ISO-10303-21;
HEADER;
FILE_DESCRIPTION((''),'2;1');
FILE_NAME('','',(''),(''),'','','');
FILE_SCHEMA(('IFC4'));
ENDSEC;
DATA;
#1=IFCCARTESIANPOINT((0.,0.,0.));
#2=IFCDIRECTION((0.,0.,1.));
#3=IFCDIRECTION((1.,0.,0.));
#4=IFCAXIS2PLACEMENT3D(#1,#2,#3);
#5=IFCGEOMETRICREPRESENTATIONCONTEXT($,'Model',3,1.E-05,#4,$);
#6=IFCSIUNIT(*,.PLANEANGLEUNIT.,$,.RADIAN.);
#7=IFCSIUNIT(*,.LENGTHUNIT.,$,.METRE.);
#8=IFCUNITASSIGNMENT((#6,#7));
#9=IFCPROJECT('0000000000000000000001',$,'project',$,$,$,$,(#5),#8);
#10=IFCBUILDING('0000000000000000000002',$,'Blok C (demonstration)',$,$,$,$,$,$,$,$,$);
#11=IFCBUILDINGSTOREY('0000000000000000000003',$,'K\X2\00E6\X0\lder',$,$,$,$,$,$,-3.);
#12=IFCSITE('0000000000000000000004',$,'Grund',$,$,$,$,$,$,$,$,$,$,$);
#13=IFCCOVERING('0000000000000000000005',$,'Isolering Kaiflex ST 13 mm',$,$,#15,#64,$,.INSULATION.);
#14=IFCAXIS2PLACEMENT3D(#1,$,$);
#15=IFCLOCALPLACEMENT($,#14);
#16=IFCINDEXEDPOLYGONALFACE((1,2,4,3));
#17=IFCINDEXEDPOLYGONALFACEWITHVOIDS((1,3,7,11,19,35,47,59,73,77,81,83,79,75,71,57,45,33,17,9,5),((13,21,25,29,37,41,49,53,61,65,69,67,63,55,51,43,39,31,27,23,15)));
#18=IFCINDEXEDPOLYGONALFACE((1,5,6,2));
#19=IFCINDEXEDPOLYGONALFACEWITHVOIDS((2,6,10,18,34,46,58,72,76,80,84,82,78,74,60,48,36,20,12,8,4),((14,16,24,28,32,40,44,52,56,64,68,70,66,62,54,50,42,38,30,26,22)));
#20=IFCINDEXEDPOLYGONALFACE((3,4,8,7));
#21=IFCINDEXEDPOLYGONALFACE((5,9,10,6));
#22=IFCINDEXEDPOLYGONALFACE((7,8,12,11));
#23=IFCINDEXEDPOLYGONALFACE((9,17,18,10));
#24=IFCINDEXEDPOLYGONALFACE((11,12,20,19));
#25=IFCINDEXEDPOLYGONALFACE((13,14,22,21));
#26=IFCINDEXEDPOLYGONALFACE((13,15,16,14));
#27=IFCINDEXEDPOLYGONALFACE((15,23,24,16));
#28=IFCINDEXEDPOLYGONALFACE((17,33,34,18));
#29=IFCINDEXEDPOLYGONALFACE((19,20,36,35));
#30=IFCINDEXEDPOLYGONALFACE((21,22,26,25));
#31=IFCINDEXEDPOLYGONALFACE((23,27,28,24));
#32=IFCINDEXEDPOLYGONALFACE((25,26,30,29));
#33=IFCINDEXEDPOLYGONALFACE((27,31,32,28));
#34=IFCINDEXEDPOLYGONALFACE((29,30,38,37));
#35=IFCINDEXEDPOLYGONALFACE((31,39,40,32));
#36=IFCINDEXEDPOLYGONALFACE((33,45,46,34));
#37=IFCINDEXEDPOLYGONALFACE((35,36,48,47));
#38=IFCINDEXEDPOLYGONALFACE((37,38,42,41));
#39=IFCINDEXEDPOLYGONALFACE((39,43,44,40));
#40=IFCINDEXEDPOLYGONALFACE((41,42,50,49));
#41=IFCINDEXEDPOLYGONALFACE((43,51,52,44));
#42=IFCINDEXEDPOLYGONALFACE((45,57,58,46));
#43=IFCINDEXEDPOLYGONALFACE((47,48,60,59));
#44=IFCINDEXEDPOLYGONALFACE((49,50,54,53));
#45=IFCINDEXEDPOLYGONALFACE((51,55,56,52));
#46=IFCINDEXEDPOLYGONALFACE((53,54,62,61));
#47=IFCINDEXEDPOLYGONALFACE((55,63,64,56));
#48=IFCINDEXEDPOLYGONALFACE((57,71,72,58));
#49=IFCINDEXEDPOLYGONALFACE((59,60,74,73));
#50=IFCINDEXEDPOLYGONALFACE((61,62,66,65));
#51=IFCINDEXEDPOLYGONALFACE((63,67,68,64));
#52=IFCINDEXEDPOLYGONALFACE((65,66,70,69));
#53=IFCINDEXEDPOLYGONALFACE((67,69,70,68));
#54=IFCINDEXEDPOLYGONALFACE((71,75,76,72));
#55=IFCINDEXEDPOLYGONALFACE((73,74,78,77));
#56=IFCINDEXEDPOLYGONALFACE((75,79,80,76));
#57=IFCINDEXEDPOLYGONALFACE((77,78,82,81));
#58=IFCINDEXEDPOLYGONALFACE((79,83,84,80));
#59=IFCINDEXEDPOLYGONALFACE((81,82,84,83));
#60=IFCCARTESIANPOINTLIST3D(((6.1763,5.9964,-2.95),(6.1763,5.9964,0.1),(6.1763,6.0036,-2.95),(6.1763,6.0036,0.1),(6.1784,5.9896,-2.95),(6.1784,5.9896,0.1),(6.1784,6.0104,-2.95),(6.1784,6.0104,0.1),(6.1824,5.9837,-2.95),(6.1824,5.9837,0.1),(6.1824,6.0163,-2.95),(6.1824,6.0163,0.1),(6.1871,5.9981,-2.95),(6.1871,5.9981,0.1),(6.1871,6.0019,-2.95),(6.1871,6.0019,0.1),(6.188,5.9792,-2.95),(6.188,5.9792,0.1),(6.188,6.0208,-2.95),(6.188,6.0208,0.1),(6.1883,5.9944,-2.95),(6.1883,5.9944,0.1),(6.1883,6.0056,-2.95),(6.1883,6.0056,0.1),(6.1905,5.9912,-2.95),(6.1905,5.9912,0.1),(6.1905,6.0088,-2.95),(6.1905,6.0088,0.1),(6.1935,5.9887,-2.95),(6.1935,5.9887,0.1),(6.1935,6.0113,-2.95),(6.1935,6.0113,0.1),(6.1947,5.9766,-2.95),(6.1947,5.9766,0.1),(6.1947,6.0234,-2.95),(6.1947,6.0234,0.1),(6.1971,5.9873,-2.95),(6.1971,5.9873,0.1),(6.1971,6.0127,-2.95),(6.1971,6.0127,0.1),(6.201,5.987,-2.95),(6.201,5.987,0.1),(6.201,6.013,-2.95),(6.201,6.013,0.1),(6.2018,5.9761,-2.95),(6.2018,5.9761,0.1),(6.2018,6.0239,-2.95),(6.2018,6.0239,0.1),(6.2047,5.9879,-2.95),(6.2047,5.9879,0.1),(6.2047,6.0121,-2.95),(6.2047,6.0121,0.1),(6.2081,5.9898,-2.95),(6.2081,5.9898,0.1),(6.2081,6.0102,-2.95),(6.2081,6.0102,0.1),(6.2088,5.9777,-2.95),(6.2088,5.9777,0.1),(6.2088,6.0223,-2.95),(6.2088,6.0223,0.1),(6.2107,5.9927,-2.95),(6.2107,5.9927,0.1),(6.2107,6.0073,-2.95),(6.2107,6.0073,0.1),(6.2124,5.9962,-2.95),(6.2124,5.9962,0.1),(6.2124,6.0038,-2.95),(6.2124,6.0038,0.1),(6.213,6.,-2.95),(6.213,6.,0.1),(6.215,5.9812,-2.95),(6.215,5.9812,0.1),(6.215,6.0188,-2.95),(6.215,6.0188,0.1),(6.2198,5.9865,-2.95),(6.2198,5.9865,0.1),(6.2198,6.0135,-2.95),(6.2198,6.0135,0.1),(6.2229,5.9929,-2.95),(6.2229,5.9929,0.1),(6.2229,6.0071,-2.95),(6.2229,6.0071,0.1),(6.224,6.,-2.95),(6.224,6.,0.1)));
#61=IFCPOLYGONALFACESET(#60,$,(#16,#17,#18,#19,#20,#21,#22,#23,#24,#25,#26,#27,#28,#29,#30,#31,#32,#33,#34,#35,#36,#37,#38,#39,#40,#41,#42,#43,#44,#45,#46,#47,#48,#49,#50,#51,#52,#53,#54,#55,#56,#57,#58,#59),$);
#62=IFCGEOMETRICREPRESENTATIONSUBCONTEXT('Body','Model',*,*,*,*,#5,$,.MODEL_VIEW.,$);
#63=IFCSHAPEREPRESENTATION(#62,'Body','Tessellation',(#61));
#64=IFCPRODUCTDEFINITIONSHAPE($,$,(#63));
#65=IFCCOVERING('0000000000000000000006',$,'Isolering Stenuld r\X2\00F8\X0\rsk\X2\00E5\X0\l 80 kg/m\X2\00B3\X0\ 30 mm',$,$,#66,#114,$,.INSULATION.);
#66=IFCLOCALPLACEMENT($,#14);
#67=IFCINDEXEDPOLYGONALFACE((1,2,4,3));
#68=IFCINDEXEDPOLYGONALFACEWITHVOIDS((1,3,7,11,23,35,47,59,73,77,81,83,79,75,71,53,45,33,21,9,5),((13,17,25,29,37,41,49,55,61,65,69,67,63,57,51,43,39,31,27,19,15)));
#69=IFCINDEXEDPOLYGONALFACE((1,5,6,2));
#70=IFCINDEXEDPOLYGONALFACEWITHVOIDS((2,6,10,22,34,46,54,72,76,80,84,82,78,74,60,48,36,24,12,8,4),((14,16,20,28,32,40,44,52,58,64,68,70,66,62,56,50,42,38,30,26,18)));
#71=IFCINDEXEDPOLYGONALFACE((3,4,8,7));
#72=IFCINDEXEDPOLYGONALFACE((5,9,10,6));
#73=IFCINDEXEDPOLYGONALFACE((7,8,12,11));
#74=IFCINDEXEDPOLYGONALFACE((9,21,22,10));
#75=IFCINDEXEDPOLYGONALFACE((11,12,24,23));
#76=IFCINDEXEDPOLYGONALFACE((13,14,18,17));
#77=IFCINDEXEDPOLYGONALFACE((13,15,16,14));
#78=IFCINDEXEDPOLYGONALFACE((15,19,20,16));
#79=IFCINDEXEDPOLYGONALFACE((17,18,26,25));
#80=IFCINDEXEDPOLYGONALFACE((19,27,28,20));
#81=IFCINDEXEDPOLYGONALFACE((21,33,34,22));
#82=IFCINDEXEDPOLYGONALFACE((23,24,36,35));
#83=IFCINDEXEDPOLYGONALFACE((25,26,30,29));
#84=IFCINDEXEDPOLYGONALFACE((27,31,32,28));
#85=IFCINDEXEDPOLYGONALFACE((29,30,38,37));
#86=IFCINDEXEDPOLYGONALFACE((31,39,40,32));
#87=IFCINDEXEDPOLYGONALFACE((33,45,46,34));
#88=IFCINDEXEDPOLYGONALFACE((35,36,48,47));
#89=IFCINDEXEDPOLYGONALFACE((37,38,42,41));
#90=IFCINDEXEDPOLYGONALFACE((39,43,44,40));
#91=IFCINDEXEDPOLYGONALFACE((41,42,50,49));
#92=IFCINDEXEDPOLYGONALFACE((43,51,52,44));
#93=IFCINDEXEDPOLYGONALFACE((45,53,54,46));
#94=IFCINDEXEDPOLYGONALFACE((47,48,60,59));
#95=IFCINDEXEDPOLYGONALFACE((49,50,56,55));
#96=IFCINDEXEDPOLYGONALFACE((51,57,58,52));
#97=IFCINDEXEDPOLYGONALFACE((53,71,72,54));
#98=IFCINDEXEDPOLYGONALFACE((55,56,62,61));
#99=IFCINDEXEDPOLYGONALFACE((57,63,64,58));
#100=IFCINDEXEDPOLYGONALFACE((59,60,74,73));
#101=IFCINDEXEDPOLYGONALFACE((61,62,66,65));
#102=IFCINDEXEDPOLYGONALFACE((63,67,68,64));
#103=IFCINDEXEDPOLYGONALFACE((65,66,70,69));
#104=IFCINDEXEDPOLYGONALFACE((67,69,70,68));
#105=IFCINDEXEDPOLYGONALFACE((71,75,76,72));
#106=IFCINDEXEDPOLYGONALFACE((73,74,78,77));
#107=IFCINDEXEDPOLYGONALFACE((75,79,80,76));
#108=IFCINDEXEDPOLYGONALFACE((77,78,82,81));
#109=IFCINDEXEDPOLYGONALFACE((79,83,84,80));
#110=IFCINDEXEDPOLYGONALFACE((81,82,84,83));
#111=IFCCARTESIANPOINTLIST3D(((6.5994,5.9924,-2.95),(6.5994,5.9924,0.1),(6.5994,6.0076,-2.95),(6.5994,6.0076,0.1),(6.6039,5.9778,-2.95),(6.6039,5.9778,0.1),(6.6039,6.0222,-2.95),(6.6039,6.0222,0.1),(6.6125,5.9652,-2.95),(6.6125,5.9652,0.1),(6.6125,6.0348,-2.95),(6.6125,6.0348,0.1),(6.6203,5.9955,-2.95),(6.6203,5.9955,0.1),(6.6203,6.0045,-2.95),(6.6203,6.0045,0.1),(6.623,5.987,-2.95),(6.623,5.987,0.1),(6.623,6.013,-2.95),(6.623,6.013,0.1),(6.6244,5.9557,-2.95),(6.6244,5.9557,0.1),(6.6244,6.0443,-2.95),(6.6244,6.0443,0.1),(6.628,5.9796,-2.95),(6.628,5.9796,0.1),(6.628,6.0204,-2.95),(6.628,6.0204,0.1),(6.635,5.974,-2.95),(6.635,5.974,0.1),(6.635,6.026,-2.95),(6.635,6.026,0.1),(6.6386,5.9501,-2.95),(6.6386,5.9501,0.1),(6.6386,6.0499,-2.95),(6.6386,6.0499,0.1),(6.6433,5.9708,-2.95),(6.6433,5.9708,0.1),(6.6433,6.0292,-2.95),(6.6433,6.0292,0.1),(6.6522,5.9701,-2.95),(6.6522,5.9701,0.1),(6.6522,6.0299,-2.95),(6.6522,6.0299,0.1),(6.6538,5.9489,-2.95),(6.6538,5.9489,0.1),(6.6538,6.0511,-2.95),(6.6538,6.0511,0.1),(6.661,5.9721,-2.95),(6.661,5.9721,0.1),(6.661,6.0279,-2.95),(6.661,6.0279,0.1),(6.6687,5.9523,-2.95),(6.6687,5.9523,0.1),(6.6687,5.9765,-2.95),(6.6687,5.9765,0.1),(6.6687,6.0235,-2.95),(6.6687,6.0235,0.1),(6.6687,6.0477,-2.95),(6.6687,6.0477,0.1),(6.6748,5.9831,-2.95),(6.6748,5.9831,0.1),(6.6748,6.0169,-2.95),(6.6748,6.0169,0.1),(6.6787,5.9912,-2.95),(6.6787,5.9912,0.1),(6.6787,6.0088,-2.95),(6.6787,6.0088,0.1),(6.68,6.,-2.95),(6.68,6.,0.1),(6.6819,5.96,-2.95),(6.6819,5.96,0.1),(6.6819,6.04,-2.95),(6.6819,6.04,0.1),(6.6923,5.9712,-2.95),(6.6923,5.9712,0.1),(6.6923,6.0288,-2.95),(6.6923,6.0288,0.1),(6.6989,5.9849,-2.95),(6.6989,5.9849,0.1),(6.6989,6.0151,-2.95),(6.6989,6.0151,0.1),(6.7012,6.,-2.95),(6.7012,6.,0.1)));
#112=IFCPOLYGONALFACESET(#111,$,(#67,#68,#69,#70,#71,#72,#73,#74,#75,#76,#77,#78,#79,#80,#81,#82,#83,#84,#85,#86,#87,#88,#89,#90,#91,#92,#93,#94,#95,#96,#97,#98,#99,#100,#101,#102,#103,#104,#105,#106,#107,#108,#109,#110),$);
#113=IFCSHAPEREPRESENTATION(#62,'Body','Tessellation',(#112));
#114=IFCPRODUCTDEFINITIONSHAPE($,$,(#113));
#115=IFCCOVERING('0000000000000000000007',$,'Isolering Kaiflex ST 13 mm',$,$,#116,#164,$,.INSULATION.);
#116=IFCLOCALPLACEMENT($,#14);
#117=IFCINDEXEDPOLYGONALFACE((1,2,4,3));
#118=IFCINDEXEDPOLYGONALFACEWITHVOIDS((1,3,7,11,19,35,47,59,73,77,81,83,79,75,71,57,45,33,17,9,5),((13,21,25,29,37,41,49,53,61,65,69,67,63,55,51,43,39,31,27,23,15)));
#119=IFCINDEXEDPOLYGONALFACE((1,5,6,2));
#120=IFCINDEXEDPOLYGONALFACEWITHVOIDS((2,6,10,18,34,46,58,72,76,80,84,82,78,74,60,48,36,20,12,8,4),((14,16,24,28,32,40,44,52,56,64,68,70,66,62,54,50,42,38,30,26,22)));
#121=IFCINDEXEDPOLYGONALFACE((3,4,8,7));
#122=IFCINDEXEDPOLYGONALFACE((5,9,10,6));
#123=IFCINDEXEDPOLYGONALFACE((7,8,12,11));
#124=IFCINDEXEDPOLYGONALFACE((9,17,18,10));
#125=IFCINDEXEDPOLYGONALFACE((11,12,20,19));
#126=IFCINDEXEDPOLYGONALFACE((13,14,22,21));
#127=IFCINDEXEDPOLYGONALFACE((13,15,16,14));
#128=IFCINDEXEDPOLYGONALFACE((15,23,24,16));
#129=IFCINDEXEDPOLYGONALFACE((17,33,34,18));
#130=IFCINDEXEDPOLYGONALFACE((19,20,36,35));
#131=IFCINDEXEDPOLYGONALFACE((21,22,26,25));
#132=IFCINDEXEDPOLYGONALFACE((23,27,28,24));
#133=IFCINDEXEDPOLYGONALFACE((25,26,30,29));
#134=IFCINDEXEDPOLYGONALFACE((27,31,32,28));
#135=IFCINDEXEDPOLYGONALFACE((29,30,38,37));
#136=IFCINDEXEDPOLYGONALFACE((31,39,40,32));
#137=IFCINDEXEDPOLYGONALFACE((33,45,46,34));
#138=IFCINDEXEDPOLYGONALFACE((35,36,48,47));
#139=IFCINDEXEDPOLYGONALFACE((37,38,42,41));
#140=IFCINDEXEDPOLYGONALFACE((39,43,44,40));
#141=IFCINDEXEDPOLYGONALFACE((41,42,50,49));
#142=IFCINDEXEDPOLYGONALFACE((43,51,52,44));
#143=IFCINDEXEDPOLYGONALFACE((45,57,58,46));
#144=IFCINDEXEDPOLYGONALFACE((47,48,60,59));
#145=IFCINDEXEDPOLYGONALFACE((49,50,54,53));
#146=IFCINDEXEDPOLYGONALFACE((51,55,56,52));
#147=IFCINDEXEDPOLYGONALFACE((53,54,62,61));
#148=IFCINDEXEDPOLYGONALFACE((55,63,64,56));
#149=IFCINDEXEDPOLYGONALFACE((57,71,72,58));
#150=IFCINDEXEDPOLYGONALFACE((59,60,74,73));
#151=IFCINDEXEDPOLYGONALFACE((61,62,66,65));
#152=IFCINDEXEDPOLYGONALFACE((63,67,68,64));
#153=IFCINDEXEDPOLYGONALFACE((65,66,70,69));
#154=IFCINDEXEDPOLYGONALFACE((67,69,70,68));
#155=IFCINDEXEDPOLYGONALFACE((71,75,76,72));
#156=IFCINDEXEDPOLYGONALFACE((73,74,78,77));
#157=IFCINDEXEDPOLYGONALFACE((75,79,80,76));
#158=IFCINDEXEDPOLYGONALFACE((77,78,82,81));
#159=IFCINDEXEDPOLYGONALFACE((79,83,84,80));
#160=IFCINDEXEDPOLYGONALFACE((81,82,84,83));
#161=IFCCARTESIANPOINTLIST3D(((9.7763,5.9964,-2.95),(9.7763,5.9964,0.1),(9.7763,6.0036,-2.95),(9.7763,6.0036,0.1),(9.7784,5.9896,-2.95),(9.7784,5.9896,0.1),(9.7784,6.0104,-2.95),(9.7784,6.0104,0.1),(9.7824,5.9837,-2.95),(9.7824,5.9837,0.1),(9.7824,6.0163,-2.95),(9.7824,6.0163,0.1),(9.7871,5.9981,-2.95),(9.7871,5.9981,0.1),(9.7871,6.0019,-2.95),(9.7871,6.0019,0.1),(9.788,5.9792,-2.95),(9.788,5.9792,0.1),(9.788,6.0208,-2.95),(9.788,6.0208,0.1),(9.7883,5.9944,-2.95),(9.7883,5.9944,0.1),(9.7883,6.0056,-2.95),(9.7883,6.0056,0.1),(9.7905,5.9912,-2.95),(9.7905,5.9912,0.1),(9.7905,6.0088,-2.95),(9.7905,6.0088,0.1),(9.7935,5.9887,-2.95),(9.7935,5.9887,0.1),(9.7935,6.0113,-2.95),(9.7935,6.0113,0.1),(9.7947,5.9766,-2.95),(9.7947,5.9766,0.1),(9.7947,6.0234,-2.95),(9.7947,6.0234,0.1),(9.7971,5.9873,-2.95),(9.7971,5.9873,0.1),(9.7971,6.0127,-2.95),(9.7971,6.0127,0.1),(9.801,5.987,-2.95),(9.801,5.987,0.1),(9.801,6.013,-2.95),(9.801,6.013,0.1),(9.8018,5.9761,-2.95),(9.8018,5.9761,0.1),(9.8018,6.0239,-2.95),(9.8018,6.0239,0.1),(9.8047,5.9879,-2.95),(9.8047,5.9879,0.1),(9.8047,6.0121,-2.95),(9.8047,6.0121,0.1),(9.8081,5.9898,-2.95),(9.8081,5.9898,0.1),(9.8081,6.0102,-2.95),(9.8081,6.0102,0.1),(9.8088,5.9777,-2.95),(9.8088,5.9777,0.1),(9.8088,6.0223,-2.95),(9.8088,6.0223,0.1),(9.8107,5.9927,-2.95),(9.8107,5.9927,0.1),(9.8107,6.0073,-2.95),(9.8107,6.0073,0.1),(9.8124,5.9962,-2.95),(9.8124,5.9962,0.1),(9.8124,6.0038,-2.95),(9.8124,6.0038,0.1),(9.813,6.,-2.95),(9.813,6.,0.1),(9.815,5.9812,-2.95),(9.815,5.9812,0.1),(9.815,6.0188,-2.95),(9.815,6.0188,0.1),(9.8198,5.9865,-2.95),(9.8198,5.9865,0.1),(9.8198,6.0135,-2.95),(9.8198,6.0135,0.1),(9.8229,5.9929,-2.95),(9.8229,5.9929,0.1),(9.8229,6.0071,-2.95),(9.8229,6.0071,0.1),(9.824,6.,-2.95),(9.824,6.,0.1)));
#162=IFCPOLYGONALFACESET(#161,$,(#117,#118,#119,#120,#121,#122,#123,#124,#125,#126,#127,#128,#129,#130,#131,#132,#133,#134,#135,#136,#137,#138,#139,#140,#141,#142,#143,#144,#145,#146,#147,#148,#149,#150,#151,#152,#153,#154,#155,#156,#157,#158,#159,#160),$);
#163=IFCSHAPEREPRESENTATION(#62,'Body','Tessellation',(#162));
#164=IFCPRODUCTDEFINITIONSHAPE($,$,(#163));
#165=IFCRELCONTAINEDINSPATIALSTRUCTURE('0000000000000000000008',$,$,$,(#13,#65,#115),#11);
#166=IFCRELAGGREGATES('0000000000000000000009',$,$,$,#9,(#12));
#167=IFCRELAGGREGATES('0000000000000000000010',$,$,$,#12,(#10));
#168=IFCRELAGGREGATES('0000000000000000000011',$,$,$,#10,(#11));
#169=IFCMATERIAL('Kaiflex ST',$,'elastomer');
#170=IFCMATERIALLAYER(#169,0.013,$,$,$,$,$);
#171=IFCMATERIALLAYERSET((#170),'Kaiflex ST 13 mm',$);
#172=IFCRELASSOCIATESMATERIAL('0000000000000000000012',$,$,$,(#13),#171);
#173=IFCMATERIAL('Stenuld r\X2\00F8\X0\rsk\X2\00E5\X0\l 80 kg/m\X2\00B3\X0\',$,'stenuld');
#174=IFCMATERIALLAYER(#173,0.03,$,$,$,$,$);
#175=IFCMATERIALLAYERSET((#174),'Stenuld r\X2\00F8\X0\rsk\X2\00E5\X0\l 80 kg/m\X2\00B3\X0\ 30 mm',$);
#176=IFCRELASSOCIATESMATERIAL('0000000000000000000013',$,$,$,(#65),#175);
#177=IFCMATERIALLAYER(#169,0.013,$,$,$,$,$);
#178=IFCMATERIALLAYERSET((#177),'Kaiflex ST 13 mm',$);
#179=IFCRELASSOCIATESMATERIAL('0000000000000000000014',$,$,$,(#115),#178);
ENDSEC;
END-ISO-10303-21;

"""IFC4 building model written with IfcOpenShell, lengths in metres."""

from ifc_helpers import new_model, si_unit, frame, origin_with_axes, place, context, subcontext, project, spatial, hollow_circle, extrude, material, layer, layer_set, element, save


model = new_model("IFC4")

# Units and contexts
model_context = context("Model", 3, precision=1e-05, world=origin_with_axes())
body_context = subcontext(model_context, "Body", "Model", "MODEL_VIEW")
ifc_project = project(units=[si_unit("PLANEANGLEUNIT", "RADIAN"), si_unit("LENGTHUNIT", "METRE")], contexts=[model_context])

# Site, building, storey
site = spatial("IfcSite", under=ifc_project, Name="Grund")
building = spatial("IfcBuilding", under=site, Name="Blok C (demonstration)")
storey = spatial("IfcBuildingStorey", under=building, Name="Kælder", Elevation=-3.0)

# Coverings
ifc_material_1 = material(Name="Kaiflex ST", Category="elastomer")
ifc_layer_1 = layer(ifc_material_1, 0.013)
ifc_layer_set_1 = layer_set([ifc_layer_1], Name="Kaiflex ST 13 mm")
covering_1_placement = place(None, origin_with_axes())
element("IfcCovering", 1, at=covering_1_placement, inside=storey, material=ifc_layer_set_1, Name="Isolering Kaiflex ST 13 mm", PredefinedType="INSULATION", context=body_context, shape_type="SweptSolid", body=[
    extrude(hollow_circle(Radius=0.024, WallThickness=0.011), frame((6.2, 6.0, -2.95), z_axis=(0.0, 0.0, 1.0), x_axis=(1.0, 0.0, 0.0)), (0.0, 0.0, 1.0), 3.05),
])
ifc_material_2 = material(Name="Stenuld rørskål 80 kg/m³", Category="stenuld")
ifc_layer_2 = layer(ifc_material_2, 0.03)
ifc_layer_set_2 = layer_set([ifc_layer_2], Name="Stenuld rørskål 80 kg/m³ 30 mm")
covering_2_placement = place(None, origin_with_axes())
element("IfcCovering", 2, at=covering_2_placement, inside=storey, material=ifc_layer_set_2, Name="Isolering Stenuld rørskål 80 kg/m³ 30 mm", PredefinedType="INSULATION", context=body_context, shape_type="SweptSolid", body=[
    extrude(hollow_circle(Radius=0.0512, WallThickness=0.0212), frame((6.65, 6.0, -2.95), z_axis=(0.0, 0.0, 1.0), x_axis=(1.0, 0.0, 0.0)), (0.0, 0.0, 1.0), 3.05),
])
ifc_layer_3 = layer(ifc_material_1, 0.013)
ifc_layer_set_3 = layer_set([ifc_layer_3], Name="Kaiflex ST 13 mm")
covering_3_placement = place(None, origin_with_axes())
element("IfcCovering", 3, at=covering_3_placement, inside=storey, material=ifc_layer_set_3, Name="Isolering Kaiflex ST 13 mm", PredefinedType="INSULATION", context=body_context, shape_type="SweptSolid", body=[
    extrude(hollow_circle(Radius=0.024, WallThickness=0.011), frame((9.8, 6.0, -2.95), z_axis=(0.0, 0.0, 1.0), x_axis=(1.0, 0.0, 0.0)), (0.0, 0.0, 1.0), 3.05),
])

save(model, "model.ifc")
